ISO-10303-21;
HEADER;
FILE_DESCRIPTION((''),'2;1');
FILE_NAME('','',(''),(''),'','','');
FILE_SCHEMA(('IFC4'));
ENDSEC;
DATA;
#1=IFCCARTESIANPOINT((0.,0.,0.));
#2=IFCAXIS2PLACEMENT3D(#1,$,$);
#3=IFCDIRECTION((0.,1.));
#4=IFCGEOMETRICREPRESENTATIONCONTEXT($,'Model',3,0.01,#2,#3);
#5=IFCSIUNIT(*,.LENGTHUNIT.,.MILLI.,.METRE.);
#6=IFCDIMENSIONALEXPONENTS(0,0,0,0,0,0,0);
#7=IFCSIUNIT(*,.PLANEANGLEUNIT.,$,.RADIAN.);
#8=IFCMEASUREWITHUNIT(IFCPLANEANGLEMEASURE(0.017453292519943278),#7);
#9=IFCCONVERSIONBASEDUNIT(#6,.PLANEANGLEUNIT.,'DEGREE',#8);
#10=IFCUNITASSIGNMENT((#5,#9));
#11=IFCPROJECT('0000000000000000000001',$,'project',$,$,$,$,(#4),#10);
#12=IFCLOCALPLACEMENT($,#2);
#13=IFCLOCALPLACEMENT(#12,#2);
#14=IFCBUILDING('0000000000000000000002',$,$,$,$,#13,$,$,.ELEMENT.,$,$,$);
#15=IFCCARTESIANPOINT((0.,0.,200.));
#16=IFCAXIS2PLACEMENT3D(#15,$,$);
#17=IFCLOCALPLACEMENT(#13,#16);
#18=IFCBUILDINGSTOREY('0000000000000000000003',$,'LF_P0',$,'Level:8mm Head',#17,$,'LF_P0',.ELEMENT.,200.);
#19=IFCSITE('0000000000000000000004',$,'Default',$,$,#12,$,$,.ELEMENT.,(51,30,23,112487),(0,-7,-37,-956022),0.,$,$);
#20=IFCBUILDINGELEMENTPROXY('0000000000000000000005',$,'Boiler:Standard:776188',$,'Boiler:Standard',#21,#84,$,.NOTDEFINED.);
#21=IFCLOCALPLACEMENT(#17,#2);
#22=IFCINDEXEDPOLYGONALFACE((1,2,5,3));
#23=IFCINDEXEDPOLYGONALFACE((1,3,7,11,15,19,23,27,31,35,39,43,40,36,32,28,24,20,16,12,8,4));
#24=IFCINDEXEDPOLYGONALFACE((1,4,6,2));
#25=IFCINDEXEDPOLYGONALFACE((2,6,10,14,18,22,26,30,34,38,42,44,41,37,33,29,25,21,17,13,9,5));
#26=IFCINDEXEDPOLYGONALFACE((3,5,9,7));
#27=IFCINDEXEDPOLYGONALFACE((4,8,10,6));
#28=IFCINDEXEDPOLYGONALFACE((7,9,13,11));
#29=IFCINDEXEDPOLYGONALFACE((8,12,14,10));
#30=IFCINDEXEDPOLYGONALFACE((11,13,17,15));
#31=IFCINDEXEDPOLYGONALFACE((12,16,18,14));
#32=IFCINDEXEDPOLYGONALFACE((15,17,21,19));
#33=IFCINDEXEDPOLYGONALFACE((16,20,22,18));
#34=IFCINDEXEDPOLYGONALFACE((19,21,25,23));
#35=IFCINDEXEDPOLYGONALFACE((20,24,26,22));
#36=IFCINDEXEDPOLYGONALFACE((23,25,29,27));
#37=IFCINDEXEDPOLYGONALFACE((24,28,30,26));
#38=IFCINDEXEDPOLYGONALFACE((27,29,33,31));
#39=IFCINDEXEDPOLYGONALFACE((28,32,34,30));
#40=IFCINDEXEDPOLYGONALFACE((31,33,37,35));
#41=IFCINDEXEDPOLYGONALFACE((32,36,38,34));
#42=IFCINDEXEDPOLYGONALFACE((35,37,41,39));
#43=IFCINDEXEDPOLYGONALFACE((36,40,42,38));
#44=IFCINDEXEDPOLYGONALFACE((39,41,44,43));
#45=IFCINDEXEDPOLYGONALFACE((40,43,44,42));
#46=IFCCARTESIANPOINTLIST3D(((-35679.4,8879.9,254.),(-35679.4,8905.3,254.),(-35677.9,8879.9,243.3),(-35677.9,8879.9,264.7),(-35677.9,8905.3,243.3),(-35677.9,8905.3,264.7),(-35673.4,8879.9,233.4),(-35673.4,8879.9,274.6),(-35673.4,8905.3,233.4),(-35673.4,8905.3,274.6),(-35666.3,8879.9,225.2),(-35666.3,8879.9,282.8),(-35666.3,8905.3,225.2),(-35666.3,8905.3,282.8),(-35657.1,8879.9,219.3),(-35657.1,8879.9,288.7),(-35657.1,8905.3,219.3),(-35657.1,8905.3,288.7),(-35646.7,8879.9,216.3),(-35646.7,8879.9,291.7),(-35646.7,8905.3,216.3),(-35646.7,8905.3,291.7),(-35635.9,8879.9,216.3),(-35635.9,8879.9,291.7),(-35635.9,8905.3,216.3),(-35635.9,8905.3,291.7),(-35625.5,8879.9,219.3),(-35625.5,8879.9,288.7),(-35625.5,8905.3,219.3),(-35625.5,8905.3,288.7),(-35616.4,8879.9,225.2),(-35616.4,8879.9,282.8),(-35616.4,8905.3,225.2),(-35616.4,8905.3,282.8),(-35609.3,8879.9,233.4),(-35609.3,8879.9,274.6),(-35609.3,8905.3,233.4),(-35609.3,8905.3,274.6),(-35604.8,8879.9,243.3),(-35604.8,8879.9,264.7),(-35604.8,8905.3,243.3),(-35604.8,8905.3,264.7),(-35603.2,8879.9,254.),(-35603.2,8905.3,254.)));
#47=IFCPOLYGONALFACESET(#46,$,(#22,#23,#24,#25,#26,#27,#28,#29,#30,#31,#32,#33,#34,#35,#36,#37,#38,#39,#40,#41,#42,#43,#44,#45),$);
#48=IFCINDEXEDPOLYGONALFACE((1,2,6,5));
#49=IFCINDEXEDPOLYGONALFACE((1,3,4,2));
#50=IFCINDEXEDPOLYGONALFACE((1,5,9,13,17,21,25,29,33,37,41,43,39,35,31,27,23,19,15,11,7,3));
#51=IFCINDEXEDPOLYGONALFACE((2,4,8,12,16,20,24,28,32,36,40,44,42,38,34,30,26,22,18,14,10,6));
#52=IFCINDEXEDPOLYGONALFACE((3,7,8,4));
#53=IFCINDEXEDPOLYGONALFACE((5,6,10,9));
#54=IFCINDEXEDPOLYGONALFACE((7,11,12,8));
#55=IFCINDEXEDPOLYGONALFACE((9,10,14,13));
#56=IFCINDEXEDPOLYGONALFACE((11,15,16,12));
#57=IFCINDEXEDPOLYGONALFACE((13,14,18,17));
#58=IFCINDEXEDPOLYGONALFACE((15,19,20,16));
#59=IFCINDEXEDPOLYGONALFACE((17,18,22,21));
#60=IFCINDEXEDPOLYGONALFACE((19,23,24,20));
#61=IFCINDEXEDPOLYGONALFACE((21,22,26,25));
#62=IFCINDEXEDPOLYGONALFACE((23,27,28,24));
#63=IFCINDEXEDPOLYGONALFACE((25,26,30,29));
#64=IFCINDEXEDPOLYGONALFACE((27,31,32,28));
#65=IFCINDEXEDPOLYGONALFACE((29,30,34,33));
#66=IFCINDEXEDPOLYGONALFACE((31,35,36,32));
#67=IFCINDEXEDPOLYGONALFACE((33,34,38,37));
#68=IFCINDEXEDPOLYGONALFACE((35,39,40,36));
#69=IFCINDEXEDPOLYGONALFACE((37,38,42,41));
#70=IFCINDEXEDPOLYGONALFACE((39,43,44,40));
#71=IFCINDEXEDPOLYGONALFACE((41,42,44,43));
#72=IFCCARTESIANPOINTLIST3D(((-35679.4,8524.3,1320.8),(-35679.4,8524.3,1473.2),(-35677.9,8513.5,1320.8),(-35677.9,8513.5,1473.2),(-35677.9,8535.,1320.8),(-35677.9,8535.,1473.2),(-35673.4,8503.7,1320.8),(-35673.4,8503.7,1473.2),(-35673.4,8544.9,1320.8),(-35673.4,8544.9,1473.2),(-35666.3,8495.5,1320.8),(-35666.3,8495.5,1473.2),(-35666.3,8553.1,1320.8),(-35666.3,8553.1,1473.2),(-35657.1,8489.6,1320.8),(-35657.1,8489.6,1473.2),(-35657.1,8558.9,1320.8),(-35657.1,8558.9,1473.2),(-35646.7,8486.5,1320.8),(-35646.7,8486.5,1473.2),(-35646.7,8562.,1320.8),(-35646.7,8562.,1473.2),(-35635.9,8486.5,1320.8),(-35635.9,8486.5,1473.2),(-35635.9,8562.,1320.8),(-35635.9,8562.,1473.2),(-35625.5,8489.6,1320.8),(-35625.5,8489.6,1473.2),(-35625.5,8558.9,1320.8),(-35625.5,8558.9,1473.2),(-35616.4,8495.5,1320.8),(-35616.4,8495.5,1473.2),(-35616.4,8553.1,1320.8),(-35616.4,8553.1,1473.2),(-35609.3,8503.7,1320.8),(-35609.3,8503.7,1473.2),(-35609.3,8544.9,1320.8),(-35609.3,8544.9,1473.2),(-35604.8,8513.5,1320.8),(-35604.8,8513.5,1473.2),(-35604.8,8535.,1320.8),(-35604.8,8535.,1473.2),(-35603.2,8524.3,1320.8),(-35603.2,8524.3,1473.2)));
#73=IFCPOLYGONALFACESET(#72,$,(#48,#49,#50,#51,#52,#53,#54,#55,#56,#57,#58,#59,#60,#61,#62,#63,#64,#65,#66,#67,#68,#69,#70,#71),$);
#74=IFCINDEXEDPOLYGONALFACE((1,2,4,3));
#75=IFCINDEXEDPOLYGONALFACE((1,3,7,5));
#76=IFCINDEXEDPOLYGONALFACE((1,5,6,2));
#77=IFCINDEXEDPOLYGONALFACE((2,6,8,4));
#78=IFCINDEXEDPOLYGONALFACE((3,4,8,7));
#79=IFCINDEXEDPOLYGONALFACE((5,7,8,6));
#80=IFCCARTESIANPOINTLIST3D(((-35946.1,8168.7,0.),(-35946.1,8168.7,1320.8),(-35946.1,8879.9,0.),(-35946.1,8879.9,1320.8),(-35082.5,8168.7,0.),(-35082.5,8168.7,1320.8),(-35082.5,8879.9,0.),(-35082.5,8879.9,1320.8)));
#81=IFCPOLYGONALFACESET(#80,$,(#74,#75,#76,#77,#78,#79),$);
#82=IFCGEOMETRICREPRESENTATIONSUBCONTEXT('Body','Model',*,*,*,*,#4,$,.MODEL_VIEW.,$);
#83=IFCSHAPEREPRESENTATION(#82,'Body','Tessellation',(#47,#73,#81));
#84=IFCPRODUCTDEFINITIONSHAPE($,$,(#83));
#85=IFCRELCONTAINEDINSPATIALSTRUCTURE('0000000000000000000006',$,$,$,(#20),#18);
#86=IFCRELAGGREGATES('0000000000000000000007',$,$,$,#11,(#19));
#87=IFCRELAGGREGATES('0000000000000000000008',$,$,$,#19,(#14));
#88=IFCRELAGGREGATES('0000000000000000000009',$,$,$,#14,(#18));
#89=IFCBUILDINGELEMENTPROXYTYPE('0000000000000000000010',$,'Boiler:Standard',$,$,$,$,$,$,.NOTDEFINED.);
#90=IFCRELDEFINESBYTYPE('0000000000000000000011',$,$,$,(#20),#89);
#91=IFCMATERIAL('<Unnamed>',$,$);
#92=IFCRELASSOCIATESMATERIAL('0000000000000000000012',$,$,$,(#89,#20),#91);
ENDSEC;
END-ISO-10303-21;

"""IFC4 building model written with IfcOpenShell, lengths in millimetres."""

from ifc_helpers import new_model, entity, si_unit, converted_unit, direction, frame, origin, place, context, subcontext, project, spatial, arc, indexed_curve, outline, extrude, source, transform, mapped, material, type_object, type_shapes, element, save


model = new_model("IFC4")

# Units and contexts
model_context = context("Model", 3, precision=0.01, world=origin(), true_north=direction((0.0, 1.0)))
body_context = subcontext(model_context, "Body", "Model", "MODEL_VIEW")
ifc_project = project(units=[si_unit("LENGTHUNIT", "METRE", prefix="MILLI"), converted_unit("PLANEANGLEUNIT", "DEGREE", entity("IfcPlaneAngleMeasure", 0.017453292519943278), si_unit("PLANEANGLEUNIT", "RADIAN"), dimensions=[0, 0, 0, 0, 0, 0, 0])], contexts=[model_context])

# Site, building, storey
site_placement = place(None, origin())
site = spatial("IfcSite", under=ifc_project, at=site_placement, Name="Default", CompositionType="ELEMENT", RefLatitude=(51, 30, 23, 112487), RefLongitude=(0, -7, -37, -956022), RefElevation=0.0)
building_placement = place(site_placement, origin())
building = spatial("IfcBuilding", under=site, at=building_placement, CompositionType="ELEMENT")
storey_placement = place(building_placement, frame((0.0, 0.0, 200.0)))
storey = spatial("IfcBuildingStorey", under=building, at=storey_placement, Name="LF_P0", ObjectType="Level:8mm Head", LongName="LF_P0", CompositionType="ELEMENT", Elevation=200.0)

# Shared definitions
ifc_material = material(Name="<Unnamed>")

# Building element proxy
building_element_proxy_type_1 = type_object("IfcBuildingElementProxyType", Name="Boiler:Standard", PredefinedType="NOTDEFINED", material=ifc_material)
shared_shape_1 = source(origin(), body_context, "Body", "SweptSolid", [
    extrude(outline(indexed_curve([(-38.1, 0.0), (0.0, -38.1), (38.1, 0.0), (0.0, 38.1)], segments=[arc(1, 2, 3), arc(3, 4, 1)], self_intersect=False)), frame((304.8, 711.2, 254.0), z_axis=(0.0, 1.0, 0.0), x_axis=(-1.0, 0.0, 0.0)), (0.0, 0.0, 1.0), 25.4),
    extrude(outline(indexed_curve([(-38.1, 0.0), (0.0, -38.1), (38.1, 0.0), (0.0, 38.1)], segments=[arc(1, 2, 3), arc(3, 4, 1)], self_intersect=False)), frame((304.8, 355.6, 1320.8)), (0.0, 0.0, 1.0), 152.4),
    extrude(outline(indexed_curve([(-355.6, -431.8), (355.6, -431.8), (355.6, 431.8), (-355.6, 431.8), (-355.6, -431.8)], self_intersect=False)), frame((431.8, 355.6, 0.0), z_axis=(0.0, 0.0, 1.0), x_axis=(0.0, 1.0, 0.0)), (0.0, 0.0, 1.0), 1320.8),
])
type_shapes(building_element_proxy_type_1, [shared_shape_1])
proxy_placement = place(storey_placement, frame((-35946.1, 8168.7, 0.0)))
element("IfcBuildingElementProxy", 1, at=proxy_placement, inside=storey, type_object=building_element_proxy_type_1, material=ifc_material, Name="Boiler:Standard:776188", ObjectType="Boiler:Standard", PredefinedType="NOTDEFINED", context=body_context, shape_type="MappedRepresentation", body=[
    mapped(shared_shape_1, transform((0.0, 0.0, 0.0), scale=1.0)),
])

save(model, "model.ifc")
